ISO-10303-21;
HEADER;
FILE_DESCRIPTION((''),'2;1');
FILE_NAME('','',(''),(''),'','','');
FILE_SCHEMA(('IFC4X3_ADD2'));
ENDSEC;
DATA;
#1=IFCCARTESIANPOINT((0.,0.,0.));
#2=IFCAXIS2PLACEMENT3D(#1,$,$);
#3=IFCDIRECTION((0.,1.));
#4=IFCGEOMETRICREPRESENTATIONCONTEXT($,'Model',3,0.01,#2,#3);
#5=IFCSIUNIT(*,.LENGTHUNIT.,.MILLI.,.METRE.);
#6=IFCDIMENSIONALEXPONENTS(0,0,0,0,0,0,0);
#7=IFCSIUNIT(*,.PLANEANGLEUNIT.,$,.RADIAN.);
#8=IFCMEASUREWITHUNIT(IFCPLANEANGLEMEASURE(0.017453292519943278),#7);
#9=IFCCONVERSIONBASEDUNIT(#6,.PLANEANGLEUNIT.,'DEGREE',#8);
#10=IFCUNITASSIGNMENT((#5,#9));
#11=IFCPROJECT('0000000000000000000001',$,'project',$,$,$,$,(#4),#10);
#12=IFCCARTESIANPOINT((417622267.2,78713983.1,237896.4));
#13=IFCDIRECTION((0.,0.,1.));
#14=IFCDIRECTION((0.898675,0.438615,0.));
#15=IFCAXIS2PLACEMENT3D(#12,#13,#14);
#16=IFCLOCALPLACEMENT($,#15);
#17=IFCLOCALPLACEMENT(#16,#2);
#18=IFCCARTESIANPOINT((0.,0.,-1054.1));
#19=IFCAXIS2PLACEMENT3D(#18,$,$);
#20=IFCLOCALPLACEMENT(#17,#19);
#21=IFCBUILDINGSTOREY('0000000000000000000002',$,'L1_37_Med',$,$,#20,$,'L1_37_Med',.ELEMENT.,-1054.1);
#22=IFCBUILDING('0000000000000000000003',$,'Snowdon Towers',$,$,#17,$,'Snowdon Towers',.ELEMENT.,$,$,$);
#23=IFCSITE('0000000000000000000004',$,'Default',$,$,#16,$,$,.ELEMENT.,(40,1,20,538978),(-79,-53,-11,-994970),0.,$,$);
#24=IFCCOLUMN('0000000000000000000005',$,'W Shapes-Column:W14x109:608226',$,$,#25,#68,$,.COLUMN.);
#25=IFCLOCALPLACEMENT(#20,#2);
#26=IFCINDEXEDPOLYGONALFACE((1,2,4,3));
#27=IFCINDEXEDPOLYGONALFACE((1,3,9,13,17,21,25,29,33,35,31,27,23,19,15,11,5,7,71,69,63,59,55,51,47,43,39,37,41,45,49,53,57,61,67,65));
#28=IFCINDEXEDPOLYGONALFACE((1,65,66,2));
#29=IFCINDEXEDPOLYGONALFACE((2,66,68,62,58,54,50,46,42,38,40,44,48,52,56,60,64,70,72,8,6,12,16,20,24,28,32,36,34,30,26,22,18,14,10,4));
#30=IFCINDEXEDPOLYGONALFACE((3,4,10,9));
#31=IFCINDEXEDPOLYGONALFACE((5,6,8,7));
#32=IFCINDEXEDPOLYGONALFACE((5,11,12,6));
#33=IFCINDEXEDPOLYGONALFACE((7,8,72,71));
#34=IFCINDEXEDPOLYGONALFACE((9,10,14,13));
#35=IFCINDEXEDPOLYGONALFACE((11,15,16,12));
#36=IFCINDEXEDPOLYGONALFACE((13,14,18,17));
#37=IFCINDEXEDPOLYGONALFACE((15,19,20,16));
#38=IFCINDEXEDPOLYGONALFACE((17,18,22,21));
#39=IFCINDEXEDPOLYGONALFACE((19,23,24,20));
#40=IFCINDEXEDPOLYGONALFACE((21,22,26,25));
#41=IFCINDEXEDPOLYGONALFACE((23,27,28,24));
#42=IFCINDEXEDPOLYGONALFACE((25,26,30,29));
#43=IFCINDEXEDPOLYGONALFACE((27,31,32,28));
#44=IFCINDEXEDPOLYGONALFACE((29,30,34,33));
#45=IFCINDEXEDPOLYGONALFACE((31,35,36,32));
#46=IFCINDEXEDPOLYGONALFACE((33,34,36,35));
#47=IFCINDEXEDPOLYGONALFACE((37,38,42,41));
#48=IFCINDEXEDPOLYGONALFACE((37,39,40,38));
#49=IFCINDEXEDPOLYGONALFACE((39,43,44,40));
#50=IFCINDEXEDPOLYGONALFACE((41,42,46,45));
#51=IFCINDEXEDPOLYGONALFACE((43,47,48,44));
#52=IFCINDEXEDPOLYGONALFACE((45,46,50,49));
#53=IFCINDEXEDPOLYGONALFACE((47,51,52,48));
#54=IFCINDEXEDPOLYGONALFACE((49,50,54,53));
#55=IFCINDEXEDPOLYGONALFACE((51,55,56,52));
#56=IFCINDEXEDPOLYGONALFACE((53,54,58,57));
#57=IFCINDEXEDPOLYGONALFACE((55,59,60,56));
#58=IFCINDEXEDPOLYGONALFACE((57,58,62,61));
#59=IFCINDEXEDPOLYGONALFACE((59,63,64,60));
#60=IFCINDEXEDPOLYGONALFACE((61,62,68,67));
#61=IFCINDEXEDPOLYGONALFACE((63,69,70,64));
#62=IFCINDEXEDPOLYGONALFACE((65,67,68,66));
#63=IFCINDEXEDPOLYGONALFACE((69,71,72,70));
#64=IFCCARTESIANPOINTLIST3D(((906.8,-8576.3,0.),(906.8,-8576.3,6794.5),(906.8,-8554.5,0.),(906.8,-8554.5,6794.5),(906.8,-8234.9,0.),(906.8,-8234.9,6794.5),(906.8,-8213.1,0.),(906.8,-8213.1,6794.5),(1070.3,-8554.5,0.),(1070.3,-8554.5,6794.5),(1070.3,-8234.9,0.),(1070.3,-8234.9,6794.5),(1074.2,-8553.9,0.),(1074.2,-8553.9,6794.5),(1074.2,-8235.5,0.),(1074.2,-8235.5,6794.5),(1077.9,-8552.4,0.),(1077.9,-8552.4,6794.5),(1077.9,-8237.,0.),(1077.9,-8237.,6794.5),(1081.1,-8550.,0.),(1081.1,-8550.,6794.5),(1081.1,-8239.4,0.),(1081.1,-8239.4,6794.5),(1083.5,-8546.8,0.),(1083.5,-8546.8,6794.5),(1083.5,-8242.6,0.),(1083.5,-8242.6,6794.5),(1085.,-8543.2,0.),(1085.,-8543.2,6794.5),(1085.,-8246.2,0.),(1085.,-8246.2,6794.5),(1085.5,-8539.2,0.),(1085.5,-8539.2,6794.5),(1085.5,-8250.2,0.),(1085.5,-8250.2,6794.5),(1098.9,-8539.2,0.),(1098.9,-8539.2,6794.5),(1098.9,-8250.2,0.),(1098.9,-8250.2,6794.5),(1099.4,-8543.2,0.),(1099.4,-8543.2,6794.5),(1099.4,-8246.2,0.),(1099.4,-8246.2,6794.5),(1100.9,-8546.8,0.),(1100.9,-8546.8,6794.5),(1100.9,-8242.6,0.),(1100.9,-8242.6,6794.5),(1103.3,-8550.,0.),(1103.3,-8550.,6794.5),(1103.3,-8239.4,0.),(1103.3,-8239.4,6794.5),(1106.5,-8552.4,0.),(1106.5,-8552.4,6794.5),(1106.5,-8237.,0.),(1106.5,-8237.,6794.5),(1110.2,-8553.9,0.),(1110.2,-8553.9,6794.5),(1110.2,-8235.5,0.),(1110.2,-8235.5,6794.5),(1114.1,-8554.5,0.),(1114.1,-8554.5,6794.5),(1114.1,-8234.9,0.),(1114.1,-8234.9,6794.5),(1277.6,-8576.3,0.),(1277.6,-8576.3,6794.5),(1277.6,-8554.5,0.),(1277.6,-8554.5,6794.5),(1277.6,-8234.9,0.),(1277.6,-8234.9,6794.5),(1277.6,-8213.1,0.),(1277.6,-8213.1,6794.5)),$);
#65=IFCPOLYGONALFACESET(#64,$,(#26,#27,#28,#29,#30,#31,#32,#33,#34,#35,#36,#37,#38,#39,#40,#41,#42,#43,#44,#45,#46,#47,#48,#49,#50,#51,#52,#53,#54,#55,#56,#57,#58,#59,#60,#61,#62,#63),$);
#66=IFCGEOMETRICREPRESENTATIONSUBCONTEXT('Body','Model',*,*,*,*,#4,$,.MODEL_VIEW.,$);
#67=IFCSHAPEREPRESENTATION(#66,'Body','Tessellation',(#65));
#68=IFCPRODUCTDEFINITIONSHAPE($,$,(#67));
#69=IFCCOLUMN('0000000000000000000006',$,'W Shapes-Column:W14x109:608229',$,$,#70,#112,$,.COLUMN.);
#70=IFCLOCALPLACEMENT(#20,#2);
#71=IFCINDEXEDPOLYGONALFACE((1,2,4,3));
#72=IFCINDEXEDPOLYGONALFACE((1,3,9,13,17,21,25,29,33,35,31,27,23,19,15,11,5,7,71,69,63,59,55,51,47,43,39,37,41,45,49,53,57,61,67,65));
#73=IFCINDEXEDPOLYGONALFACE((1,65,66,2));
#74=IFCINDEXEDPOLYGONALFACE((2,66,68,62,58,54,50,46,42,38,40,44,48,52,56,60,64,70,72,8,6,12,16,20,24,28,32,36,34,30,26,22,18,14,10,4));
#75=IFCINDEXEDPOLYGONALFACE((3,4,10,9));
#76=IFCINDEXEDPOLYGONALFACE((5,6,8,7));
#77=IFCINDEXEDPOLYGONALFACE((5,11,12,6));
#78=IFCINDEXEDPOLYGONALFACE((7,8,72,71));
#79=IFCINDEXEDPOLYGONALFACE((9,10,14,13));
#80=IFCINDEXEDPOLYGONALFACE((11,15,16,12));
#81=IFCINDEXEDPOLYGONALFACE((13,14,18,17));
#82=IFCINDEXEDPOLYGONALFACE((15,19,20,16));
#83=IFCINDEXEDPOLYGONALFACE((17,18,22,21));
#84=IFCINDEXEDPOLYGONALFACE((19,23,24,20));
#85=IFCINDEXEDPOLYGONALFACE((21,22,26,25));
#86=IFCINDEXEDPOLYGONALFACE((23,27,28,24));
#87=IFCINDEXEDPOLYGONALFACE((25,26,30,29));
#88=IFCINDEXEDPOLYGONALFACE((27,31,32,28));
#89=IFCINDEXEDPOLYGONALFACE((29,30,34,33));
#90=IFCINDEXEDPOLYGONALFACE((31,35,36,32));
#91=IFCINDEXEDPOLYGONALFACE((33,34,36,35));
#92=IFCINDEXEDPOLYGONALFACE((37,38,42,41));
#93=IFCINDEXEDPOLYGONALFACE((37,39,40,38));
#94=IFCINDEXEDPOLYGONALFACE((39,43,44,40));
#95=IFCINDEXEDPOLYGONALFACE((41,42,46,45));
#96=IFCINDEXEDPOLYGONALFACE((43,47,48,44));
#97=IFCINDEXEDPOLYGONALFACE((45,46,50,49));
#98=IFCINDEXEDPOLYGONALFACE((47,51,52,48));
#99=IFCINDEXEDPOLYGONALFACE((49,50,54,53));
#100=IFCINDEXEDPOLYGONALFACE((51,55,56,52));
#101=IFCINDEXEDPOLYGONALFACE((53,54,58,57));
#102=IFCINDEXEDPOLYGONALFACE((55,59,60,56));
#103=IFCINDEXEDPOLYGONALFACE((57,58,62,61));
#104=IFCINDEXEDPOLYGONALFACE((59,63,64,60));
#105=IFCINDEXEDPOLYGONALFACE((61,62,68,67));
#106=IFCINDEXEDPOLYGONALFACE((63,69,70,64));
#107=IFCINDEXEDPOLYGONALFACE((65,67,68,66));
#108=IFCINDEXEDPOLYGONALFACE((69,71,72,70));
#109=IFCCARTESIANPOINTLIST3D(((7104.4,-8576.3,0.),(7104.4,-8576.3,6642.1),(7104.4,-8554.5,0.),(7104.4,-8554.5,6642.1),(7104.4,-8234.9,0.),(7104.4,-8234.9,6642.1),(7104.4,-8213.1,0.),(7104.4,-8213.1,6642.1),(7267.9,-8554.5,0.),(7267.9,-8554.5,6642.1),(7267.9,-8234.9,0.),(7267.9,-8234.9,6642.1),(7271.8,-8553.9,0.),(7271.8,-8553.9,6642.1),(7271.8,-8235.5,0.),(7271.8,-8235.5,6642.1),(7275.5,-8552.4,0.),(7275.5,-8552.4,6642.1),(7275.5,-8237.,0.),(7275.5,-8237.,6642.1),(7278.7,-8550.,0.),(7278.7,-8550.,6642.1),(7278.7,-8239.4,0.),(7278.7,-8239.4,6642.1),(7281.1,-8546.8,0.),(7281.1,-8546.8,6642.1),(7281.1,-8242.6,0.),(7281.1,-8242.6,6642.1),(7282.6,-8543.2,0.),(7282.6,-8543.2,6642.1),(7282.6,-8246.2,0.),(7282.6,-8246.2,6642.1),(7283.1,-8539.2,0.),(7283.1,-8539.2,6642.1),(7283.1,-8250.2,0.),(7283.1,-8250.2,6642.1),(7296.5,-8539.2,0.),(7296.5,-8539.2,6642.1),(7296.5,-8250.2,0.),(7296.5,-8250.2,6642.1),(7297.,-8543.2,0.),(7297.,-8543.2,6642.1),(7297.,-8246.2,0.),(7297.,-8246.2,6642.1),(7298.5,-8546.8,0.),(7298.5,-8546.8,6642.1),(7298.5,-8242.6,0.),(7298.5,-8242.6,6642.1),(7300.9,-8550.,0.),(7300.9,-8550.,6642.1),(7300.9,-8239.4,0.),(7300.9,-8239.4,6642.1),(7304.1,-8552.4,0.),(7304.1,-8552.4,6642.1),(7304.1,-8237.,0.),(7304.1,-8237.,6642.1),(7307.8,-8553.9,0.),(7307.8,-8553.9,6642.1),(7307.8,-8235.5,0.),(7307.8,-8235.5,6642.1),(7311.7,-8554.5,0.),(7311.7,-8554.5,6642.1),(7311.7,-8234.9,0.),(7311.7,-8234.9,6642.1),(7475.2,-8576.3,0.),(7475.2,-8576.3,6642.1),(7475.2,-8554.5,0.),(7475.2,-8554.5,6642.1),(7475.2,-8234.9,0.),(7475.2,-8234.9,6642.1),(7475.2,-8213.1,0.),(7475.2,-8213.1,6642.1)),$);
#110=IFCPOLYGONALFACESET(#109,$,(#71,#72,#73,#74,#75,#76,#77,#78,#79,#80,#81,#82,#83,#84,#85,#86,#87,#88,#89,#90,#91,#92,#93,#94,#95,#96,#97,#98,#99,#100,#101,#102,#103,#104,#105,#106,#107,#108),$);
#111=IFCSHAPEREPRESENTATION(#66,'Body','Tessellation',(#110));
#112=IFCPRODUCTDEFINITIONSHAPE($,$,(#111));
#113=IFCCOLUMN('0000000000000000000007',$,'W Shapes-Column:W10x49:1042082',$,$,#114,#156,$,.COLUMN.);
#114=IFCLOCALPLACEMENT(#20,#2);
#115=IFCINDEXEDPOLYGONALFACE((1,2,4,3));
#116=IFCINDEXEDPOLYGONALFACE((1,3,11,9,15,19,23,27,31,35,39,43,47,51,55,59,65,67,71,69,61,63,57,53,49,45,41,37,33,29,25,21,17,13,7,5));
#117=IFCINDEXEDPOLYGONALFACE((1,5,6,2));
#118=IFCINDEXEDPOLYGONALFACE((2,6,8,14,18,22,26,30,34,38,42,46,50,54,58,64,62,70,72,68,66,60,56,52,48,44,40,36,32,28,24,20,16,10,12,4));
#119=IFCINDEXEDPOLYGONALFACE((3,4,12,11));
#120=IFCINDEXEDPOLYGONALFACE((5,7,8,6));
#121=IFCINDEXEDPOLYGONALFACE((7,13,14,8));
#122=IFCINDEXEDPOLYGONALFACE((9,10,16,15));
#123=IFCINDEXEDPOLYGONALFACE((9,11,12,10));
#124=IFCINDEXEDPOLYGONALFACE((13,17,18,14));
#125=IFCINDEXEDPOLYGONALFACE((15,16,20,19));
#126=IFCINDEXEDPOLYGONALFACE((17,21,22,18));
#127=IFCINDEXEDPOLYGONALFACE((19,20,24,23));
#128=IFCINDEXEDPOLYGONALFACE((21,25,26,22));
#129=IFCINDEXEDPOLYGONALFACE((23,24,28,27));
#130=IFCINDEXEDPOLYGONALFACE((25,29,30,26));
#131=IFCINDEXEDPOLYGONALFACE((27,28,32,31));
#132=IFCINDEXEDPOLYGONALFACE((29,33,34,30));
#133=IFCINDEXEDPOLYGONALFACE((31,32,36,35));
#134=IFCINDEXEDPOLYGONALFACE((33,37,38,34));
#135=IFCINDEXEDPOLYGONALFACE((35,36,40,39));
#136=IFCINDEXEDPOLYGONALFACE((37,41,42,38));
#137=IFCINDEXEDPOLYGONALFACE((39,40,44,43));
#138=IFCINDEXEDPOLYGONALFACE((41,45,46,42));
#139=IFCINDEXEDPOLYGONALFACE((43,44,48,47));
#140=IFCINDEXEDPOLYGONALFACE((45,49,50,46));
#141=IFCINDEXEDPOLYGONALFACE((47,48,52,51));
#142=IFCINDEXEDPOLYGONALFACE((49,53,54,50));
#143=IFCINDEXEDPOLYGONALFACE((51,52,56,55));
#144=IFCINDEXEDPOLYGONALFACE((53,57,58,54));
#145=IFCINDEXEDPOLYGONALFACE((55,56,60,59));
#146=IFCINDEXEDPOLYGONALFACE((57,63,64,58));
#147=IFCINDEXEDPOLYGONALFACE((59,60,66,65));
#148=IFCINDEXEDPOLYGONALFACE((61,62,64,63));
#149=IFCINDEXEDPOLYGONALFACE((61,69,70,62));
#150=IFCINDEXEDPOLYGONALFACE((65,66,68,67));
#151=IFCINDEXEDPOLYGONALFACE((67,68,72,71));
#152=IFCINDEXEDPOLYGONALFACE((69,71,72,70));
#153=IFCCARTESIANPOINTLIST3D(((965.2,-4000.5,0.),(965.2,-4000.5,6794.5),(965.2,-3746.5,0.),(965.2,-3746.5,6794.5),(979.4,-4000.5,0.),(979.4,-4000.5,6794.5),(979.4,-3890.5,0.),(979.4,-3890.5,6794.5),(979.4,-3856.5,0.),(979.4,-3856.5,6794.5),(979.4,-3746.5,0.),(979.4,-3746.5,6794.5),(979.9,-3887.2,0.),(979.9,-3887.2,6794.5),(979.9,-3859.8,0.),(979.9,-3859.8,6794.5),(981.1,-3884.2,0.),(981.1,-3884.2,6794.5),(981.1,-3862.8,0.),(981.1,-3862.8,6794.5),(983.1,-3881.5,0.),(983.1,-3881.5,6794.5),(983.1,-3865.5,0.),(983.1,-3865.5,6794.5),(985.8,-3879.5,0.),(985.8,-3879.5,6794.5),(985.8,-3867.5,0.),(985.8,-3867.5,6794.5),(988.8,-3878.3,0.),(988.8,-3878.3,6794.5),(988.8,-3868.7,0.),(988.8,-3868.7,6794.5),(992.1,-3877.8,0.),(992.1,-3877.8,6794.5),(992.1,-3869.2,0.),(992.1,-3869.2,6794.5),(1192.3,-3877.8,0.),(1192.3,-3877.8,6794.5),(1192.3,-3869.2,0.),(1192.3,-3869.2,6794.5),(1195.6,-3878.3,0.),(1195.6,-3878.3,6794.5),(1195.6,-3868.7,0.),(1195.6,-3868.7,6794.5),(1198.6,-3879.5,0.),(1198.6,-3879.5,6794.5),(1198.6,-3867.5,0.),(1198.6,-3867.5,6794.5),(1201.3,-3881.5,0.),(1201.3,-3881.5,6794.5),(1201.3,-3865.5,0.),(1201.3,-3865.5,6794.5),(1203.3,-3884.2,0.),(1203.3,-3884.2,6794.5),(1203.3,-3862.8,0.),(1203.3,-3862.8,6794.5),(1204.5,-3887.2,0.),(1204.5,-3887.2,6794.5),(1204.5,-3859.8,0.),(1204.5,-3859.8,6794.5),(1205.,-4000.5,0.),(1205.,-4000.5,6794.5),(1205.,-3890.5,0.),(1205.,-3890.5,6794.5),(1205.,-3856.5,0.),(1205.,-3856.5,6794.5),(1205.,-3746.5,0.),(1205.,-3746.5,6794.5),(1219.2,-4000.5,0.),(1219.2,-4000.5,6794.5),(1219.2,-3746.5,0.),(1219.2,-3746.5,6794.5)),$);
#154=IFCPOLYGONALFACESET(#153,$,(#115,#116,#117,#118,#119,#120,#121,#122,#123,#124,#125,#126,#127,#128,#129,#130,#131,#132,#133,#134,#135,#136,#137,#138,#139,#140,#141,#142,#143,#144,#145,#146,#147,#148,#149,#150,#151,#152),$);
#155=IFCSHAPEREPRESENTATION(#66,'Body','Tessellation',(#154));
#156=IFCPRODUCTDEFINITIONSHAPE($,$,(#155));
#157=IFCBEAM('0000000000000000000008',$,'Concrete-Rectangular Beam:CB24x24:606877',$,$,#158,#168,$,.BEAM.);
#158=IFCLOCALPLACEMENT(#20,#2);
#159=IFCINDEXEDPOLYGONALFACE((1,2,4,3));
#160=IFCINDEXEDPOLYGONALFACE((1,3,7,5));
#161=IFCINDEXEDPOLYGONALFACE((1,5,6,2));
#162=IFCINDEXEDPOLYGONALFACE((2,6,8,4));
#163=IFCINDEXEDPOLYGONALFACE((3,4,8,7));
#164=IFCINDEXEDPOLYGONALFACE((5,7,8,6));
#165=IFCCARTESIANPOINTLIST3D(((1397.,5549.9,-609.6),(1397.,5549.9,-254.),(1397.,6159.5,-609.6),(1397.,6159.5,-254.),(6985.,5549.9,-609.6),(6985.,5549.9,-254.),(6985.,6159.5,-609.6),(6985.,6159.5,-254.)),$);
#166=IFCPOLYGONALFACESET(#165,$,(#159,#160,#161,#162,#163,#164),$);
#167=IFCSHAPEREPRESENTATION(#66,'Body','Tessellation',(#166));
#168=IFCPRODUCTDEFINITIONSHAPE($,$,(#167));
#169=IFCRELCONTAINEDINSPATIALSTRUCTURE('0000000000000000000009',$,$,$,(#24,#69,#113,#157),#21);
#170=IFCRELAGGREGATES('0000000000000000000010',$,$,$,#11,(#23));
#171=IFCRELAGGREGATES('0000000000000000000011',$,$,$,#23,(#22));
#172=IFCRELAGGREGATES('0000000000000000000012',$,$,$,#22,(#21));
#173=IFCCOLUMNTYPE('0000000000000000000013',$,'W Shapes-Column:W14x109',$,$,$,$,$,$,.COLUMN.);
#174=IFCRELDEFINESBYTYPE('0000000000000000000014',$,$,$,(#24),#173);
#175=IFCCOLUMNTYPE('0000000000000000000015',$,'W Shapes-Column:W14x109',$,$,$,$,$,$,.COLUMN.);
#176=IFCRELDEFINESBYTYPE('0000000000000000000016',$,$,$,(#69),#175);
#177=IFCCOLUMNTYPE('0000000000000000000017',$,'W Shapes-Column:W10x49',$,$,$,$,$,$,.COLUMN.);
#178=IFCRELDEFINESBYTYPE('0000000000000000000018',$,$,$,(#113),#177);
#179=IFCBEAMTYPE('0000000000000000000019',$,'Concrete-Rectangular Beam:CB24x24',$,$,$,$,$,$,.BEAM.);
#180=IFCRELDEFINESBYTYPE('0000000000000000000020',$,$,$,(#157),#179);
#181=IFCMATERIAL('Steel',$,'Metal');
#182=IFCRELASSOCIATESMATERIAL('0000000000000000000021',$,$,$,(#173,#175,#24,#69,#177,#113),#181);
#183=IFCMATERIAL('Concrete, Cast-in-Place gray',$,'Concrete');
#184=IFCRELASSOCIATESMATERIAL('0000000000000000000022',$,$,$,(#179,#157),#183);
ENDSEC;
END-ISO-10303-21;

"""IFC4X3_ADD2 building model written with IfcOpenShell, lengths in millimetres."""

from ifc_helpers import new_model, entity, si_unit, converted_unit, direction, frame, frame_2d, origin, place, context, subcontext, project, spatial, rectangle, i_section, extrude, source, transform, mapped, material, material_profile, profile_set, profile_usage, type_object, type_shapes, element, save


model = new_model("IFC4X3_ADD2")

# Units and contexts
model_context = context("Model", 3, precision=0.01, world=origin(), true_north=direction((0.0, 1.0)))
body_context = subcontext(model_context, "Body", "Model", "MODEL_VIEW")
ifc_project = project(units=[si_unit("LENGTHUNIT", "METRE", prefix="MILLI"), converted_unit("PLANEANGLEUNIT", "DEGREE", entity("IfcPlaneAngleMeasure", 0.017453292519943278), si_unit("PLANEANGLEUNIT", "RADIAN"), dimensions=[0, 0, 0, 0, 0, 0, 0])], contexts=[model_context])

# Site, building, storey
site_placement = place(None, frame((417622267.2, 78713983.1, 237896.4), z_axis=(0.0, 0.0, 1.0), x_axis=(0.898675, 0.438615, 0.0)))
site = spatial("IfcSite", under=ifc_project, at=site_placement, Name="Default", CompositionType="ELEMENT", RefLatitude=(40, 1, 20, 538978), RefLongitude=(-79, -53, -11, -994970), RefElevation=0.0)
building_placement = place(site_placement, origin())
building = spatial("IfcBuilding", under=site, at=building_placement, Name="Snowdon Towers", LongName="Snowdon Towers", CompositionType="ELEMENT")
storey_placement = place(building_placement, frame((0.0, 0.0, -1054.1)))
storey = spatial("IfcBuildingStorey", under=building, at=storey_placement, Name="L1_37_Med", LongName="L1_37_Med", CompositionType="ELEMENT", Elevation=-1054.1)

# Columns
ifc_material_1 = material(Name="Steel", Category="Metal")
ifc_material_profile_1 = material_profile(ifc_material_1, i_section(OverallWidth=370.8, OverallDepth=363.2, WebThickness=13.3, FlangeThickness=21.8, FilletRadius=15.2, at=frame_2d((0.0, 0.0), x_axis=(1.0, 0.0))), Name="W14x109")
ifc_profile_set_1 = profile_set([ifc_material_profile_1], Name="W14x109")
ifc_profile_usage_1 = profile_usage(ifc_profile_set_1)
ifc_material_profile_2 = material_profile(ifc_material_1, i_section(OverallWidth=254.0, OverallDepth=254.0, WebThickness=8.6, FlangeThickness=14.2, FilletRadius=12.7, at=frame_2d((0.0, 0.0), x_axis=(1.0, 0.0))), Name="W10x49")
ifc_profile_set_2 = profile_set([ifc_material_profile_2], Name="W10x49")
ifc_profile_usage_2 = profile_usage(ifc_profile_set_2)
column_type_1 = type_object("IfcColumnType", Name="W Shapes-Column:W14x109", PredefinedType="COLUMN", material=ifc_profile_set_1)
shared_shape_1 = source(origin(), body_context, "Body", "SweptSolid", [
    extrude(i_section(OverallWidth=370.8, OverallDepth=363.2, WebThickness=13.3, FlangeThickness=21.8, FilletRadius=15.2, at=frame_2d((0.0, 0.0), x_axis=(1.0, 0.0))), frame((0.0, 0.0, -1054.1), z_axis=(0.0, 0.0, 1.0), x_axis=(-1.0, 0.0, 0.0)), (0.0, 0.0, 1.0), 6794.5),
])
type_shapes(column_type_1, [shared_shape_1])
column_1_placement = place(storey_placement, frame((1092.2, -8394.7, 1054.1), z_axis=(0.0, 0.0, 1.0), x_axis=(-1.0, 0.0, 0.0)))
element("IfcColumn", 1, at=column_1_placement, inside=storey, type_object=column_type_1, material=ifc_profile_usage_1, Name="W Shapes-Column:W14x109:608226", PredefinedType="COLUMN", context=body_context, shape_type="MappedRepresentation", body=[
    mapped(shared_shape_1, transform((0.0, 0.0, 0.0), scale=1.0)),
])
column_type_2 = type_object("IfcColumnType", Name="W Shapes-Column:W14x109", PredefinedType="COLUMN", material=ifc_profile_set_1)
shared_shape_2 = source(origin(), body_context, "Body", "SweptSolid", [
    extrude(i_section(OverallWidth=370.8, OverallDepth=363.2, WebThickness=13.3, FlangeThickness=21.8, FilletRadius=15.2, at=frame_2d((0.0, 0.0), x_axis=(1.0, 0.0))), frame((0.0, 0.0, -1054.1), z_axis=(0.0, 0.0, 1.0), x_axis=(-1.0, 0.0, 0.0)), (0.0, 0.0, 1.0), 6642.1),
])
type_shapes(column_type_2, [shared_shape_2])
column_2_placement = place(storey_placement, frame((7289.8, -8394.7, 1054.1), z_axis=(0.0, 0.0, 1.0), x_axis=(-1.0, 0.0, 0.0)))
element("IfcColumn", 2, at=column_2_placement, inside=storey, type_object=column_type_2, material=ifc_profile_usage_1, Name="W Shapes-Column:W14x109:608229", PredefinedType="COLUMN", context=body_context, shape_type="MappedRepresentation", body=[
    mapped(shared_shape_2, transform((0.0, 0.0, 0.0), scale=1.0)),
])
column_type_3 = type_object("IfcColumnType", Name="W Shapes-Column:W10x49", PredefinedType="COLUMN", material=ifc_profile_set_2)
shared_shape_3 = source(origin(), body_context, "Body", "SweptSolid", [
    extrude(i_section(OverallWidth=254.0, OverallDepth=254.0, WebThickness=8.6, FlangeThickness=14.2, FilletRadius=12.7, at=frame_2d((0.0, 0.0), x_axis=(1.0, 0.0))), frame((0.0, 0.0, -1054.1), z_axis=(0.0, 0.0, 1.0), x_axis=(-1.0, 0.0, 0.0)), (0.0, 0.0, 1.0), 6794.5),
])
type_shapes(column_type_3, [shared_shape_3])
column_3_placement = place(storey_placement, frame((1092.2, -3873.5, 1054.1), z_axis=(0.0, 0.0, 1.0), x_axis=(0.0, 1.0, 0.0)))
element("IfcColumn", 3, at=column_3_placement, inside=storey, type_object=column_type_3, material=ifc_profile_usage_2, Name="W Shapes-Column:W10x49:1042082", PredefinedType="COLUMN", context=body_context, shape_type="MappedRepresentation", body=[
    mapped(shared_shape_3, transform((0.0, 0.0, 0.0), scale=1.0)),
])

# Beam
ifc_material_2 = material(Name="Concrete, Cast-in-Place gray", Category="Concrete")
ifc_material_profile_3 = material_profile(ifc_material_2, rectangle(XDim=355.6, YDim=609.6, at=frame_2d((0.0, 0.0), x_axis=(1.0, 0.0))), Name="CB24x24")
ifc_profile_set_3 = profile_set([ifc_material_profile_3], Name="CB24x24")
ifc_profile_usage_3 = profile_usage(ifc_profile_set_3, cardinal=8)
beam_type_1 = type_object("IfcBeamType", Name="Concrete-Rectangular Beam:CB24x24", PredefinedType="BEAM", material=ifc_profile_set_3)
shared_shape_4 = source(origin(), body_context, "Body", "SweptSolid", [
    extrude(rectangle(XDim=355.6, YDim=609.6, at=frame_2d((0.0, 0.0), x_axis=(1.0, 0.0))), frame((1397.0, 5854.7, -1485.9), z_axis=(1.0, 0.0, 0.0), x_axis=(0.0, 0.0, -1.0)), (0.0, 0.0, 1.0), 5588.0),
])
type_shapes(beam_type_1, [shared_shape_4])
beam_1_placement = place(storey_placement, frame((0.0, 0.0, 1054.1)))
element("IfcBeam", 4, at=beam_1_placement, inside=storey, type_object=beam_type_1, material=ifc_profile_usage_3, Name="Concrete-Rectangular Beam:CB24x24:606877", PredefinedType="BEAM", context=body_context, shape_type="MappedRepresentation", body=[
    mapped(shared_shape_4, transform((0.0, 0.0, 0.0), scale=1.0)),
])

save(model, "model.ifc")
